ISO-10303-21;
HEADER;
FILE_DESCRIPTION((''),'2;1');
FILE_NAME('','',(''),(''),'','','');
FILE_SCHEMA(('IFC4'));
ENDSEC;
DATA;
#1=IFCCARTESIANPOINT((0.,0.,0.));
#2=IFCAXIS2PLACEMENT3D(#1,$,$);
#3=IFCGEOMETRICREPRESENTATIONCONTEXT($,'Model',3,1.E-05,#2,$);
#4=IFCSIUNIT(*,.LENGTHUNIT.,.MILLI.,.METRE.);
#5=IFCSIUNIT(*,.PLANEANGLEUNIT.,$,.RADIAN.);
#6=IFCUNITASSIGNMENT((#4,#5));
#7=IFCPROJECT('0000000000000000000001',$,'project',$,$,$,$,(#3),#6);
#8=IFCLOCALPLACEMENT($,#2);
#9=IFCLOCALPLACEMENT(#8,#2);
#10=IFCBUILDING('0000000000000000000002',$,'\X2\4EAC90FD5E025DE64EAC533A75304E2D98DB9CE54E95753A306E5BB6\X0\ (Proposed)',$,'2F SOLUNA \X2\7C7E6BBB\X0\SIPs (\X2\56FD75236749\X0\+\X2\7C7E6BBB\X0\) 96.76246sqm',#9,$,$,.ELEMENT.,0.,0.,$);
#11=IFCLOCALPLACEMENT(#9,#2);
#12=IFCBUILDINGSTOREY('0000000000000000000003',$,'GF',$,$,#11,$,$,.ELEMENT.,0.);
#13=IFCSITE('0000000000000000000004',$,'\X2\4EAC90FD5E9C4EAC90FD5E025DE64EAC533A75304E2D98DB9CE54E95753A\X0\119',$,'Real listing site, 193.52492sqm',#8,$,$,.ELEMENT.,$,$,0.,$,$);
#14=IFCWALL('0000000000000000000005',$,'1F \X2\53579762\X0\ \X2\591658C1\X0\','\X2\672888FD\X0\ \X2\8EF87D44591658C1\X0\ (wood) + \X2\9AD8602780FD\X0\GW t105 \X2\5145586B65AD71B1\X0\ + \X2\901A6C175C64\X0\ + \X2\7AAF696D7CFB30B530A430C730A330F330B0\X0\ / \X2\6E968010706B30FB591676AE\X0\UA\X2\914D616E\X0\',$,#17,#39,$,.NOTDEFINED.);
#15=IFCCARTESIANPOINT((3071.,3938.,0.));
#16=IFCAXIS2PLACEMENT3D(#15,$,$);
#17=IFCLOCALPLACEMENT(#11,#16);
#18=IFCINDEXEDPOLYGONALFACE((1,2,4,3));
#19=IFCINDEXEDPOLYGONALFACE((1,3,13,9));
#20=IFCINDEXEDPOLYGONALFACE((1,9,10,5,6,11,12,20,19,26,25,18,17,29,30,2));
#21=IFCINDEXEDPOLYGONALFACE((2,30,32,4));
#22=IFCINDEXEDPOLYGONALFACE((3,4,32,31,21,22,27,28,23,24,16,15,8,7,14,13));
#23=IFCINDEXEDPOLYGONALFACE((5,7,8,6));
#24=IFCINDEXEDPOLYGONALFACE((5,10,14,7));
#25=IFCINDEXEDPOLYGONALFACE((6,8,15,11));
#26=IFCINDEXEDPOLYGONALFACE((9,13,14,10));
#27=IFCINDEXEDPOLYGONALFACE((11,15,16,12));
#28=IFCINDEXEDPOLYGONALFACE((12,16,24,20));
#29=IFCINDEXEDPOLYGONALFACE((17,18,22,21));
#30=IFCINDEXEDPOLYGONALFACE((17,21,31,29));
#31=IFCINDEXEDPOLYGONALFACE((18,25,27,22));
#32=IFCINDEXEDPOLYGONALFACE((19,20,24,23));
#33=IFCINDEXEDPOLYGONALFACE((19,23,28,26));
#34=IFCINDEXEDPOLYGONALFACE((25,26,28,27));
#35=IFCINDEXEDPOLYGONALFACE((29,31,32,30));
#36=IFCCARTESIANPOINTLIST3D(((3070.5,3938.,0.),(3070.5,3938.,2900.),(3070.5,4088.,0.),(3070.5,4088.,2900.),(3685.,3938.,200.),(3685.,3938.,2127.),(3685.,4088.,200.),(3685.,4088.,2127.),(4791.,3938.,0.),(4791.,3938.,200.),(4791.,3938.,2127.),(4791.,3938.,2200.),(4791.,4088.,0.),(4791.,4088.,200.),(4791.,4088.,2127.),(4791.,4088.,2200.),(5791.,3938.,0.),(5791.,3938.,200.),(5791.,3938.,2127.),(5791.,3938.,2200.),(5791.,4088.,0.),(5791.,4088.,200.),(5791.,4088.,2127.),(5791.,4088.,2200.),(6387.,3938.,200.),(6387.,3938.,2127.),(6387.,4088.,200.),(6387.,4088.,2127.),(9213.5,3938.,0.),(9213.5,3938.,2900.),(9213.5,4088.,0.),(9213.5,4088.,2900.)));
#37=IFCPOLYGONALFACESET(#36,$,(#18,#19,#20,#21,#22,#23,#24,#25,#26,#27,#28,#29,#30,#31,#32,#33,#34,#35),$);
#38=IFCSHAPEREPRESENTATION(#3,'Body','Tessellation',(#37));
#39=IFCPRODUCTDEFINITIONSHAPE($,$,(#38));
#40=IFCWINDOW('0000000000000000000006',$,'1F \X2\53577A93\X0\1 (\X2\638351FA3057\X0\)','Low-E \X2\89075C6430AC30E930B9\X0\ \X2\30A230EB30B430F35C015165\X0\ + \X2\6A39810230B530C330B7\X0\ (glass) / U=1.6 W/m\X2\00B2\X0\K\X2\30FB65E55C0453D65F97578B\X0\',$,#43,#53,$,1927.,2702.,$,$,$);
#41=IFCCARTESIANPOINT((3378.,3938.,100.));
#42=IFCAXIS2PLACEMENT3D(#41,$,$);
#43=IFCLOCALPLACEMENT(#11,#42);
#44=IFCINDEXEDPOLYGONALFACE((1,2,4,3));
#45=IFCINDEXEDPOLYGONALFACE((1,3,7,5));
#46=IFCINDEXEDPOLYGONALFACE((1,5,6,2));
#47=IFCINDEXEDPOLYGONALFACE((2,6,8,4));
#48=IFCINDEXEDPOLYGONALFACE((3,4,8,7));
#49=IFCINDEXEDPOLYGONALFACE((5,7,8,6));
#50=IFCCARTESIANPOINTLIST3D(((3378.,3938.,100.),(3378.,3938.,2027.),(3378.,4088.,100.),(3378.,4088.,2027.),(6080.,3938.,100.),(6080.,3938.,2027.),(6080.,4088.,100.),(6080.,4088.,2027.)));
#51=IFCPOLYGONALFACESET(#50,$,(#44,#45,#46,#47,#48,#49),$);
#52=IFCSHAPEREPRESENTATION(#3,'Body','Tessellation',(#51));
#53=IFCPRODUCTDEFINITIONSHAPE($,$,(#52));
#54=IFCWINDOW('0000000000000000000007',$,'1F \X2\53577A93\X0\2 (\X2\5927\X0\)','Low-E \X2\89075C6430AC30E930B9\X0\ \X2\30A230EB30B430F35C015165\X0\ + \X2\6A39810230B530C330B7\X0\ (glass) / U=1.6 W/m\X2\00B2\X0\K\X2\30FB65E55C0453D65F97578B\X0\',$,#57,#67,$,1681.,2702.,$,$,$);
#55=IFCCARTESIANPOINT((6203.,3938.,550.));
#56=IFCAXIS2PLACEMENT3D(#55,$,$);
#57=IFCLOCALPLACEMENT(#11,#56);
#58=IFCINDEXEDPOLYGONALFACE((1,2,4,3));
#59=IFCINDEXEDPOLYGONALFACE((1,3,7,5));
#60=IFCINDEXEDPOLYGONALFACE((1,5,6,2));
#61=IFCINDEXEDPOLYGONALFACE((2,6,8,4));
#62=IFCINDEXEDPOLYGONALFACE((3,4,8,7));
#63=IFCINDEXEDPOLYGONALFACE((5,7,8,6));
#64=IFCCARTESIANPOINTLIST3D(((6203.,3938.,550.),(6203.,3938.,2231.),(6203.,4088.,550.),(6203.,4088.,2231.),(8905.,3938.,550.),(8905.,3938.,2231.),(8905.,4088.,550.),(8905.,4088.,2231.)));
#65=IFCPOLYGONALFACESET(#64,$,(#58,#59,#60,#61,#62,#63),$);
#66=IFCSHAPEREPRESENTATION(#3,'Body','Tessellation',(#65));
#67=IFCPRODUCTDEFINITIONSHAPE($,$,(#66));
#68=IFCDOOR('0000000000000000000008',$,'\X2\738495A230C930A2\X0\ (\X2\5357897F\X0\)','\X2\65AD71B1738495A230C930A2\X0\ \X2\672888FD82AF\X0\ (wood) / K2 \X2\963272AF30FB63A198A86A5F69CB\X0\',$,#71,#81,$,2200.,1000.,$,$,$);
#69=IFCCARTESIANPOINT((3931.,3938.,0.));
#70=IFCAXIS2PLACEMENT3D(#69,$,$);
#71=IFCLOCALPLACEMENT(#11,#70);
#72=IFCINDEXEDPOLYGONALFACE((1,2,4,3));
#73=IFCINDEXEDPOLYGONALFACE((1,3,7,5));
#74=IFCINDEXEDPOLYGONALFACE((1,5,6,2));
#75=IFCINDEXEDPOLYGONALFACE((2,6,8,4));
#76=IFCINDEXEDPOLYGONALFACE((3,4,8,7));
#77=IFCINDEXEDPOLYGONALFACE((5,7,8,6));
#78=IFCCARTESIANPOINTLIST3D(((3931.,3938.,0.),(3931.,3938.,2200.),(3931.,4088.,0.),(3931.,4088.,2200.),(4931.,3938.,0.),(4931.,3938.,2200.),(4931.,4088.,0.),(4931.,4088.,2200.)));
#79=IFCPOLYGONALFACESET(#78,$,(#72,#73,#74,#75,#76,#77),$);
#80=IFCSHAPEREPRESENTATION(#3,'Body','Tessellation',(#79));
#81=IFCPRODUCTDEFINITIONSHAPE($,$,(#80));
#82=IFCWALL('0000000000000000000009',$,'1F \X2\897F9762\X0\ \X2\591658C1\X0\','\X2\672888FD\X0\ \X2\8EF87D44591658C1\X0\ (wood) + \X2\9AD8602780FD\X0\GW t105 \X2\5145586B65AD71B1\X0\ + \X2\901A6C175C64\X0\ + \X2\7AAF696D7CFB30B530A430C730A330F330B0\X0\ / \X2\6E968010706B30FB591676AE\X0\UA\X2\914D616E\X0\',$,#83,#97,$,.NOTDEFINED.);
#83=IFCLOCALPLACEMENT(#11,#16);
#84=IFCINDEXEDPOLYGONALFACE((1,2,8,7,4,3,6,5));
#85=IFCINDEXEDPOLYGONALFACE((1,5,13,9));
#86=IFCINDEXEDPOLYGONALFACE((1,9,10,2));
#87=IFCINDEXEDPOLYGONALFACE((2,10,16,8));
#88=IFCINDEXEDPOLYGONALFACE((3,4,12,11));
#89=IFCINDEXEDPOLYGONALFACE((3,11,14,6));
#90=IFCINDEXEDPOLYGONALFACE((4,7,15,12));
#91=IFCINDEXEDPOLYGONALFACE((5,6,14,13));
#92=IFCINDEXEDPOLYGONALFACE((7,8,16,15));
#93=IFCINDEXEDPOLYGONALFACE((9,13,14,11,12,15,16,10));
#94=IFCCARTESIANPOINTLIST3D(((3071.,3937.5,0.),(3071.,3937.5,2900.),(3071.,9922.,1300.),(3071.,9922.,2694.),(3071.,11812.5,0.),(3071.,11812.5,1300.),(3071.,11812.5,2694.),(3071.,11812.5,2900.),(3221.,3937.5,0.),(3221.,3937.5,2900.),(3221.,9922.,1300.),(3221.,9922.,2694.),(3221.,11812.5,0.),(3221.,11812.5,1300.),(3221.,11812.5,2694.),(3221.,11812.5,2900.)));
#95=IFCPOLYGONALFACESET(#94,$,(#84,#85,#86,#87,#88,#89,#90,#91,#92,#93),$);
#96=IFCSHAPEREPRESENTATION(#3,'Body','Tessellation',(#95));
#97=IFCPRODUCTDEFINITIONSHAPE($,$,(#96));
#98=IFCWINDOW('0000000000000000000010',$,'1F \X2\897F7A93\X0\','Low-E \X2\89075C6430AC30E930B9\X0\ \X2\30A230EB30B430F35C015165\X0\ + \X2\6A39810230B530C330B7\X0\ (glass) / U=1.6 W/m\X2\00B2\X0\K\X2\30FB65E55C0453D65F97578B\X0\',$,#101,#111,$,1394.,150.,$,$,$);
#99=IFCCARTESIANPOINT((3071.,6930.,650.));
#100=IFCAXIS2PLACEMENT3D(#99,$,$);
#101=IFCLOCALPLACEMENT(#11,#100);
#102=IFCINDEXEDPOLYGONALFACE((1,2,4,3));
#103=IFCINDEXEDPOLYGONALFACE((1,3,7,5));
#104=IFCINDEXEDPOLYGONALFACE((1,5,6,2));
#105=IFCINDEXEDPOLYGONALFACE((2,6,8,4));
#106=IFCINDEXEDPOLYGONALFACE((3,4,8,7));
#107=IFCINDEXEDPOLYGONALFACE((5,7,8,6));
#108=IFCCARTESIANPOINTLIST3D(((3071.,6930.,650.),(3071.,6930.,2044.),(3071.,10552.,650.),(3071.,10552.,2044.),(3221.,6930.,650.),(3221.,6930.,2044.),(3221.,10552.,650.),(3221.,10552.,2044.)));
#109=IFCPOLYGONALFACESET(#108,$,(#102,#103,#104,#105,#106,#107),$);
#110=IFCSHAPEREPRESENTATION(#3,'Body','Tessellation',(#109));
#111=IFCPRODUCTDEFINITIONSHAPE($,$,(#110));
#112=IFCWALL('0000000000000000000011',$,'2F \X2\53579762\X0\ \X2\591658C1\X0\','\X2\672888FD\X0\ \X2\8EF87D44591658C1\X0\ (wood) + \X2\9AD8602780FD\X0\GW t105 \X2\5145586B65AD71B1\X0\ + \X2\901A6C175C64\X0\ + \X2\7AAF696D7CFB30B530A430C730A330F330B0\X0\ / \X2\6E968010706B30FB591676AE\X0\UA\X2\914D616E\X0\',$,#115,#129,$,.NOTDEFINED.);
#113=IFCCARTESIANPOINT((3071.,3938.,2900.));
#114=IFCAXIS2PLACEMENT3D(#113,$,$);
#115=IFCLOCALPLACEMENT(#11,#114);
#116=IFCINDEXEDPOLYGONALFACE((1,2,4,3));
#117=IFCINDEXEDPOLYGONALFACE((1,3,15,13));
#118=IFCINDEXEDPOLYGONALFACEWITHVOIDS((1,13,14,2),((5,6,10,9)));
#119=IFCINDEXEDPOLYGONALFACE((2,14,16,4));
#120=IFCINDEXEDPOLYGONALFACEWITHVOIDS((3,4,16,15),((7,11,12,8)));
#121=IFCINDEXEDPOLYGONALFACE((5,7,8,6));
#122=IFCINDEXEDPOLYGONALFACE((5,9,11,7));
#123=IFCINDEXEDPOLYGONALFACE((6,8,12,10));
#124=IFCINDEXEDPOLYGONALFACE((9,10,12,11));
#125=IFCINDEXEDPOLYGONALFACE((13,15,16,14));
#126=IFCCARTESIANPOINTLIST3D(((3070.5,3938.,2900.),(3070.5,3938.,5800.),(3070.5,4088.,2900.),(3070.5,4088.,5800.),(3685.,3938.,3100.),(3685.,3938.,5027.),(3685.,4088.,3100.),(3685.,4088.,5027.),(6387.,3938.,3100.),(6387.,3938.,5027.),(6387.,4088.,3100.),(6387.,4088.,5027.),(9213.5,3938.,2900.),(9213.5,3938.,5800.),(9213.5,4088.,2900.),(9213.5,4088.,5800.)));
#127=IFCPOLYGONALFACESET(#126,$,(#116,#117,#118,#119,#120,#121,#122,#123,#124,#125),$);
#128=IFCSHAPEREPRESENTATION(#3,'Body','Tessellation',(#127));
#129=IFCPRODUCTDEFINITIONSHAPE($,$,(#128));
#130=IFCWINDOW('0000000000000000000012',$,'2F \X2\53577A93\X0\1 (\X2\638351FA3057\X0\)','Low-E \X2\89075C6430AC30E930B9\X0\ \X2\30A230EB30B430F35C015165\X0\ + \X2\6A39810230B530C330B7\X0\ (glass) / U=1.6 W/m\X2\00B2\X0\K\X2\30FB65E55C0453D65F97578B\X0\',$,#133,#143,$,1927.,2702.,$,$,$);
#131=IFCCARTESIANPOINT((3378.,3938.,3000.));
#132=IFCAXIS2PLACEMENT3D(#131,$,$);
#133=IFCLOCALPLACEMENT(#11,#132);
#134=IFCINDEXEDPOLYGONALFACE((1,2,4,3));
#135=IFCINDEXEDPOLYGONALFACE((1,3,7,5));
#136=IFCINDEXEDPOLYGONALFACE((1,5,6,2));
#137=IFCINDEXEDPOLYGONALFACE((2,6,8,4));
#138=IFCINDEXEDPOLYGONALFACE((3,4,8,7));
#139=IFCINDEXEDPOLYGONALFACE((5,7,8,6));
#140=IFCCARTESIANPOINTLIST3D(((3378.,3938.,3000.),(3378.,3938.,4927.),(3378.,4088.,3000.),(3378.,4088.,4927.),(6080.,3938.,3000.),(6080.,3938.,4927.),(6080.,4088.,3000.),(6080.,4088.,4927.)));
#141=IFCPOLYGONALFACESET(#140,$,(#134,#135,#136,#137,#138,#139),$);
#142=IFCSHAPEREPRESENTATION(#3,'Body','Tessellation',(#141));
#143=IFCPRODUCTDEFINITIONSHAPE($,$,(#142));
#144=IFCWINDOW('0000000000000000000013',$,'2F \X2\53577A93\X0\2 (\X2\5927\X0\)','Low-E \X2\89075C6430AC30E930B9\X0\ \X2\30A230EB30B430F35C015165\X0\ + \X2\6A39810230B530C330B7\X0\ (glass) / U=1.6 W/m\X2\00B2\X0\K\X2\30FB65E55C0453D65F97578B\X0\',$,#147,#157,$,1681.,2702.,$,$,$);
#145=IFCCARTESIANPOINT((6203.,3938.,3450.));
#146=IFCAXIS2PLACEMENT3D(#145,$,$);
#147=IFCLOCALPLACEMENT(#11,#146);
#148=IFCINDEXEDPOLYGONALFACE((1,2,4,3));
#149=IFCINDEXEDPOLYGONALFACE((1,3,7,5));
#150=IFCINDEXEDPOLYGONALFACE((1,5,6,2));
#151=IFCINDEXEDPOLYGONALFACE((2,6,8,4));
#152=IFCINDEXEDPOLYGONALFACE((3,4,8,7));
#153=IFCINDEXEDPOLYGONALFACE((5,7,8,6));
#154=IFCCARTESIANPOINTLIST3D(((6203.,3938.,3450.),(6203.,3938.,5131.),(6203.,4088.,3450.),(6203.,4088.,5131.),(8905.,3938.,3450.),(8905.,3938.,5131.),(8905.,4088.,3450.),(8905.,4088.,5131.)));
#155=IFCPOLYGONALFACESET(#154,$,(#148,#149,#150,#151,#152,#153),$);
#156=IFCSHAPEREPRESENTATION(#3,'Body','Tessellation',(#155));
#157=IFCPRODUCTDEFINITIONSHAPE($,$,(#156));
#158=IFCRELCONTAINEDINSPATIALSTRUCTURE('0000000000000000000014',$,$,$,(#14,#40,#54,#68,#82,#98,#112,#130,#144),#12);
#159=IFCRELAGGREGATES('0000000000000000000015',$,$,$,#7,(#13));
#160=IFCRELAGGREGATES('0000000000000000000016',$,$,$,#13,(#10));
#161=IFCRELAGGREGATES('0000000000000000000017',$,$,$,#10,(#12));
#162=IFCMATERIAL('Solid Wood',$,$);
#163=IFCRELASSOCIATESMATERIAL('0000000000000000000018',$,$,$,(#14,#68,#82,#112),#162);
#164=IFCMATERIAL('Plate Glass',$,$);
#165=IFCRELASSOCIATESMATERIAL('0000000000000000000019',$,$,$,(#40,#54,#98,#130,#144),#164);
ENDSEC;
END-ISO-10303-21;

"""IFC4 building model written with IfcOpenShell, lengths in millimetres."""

from ifc_helpers import new_model, si_unit, frame, frame_2d, origin, place, context, project, spatial, rectangle, extrude, material, element, fill, save


model = new_model("IFC4")

# Units and contexts
model_context = context("Model", 3, precision=1e-05, world=origin())
ifc_project = project(units=[si_unit("LENGTHUNIT", "METRE", prefix="MILLI"), si_unit("PLANEANGLEUNIT", "RADIAN")], contexts=[model_context])

# Site, building, storey
site_placement = place(None, origin())
site = spatial("IfcSite", under=ifc_project, at=site_placement, Name="京都府京都市左京区田中飛鳥井町119", ObjectType="Real listing site, 193.52492sqm", CompositionType="ELEMENT", RefElevation=0.0)
building_placement = place(site_placement, origin())
building = spatial("IfcBuilding", under=site, at=building_placement, Name="京都市左京区田中飛鳥井町の家 (Proposed)", ObjectType="2F SOLUNA 籾殻SIPs (国産杉+籾殻) 96.76246sqm", CompositionType="ELEMENT", ElevationOfRefHeight=0.0, ElevationOfTerrain=0.0)
storey_placement = place(building_placement, origin())
storey = spatial("IfcBuildingStorey", under=building, at=storey_placement, Name="GF", CompositionType="ELEMENT", Elevation=0.0)

# Shared definitions
ifc_material_1 = material(Name="Solid Wood")

# Wall, openings, windows, door
wall_1_placement = place(storey_placement, frame((3071.0, 3938.0, 0.0)))
wall_1 = element("IfcWall", 1, at=wall_1_placement, inside=storey, material=ifc_material_1, Name="1F 南面 外壁", Description="木製 軸組外壁 (wood) + 高性能GW t105 充填断熱 + 通気層 + 窯業系サイディング / 準耐火・外皮UA配慮", PredefinedType="NOTDEFINED", context=model_context, shape_type="SweptSolid", body=[
    extrude(rectangle(XDim=6143.0, YDim=150.0, at=frame_2d((3071.0, 75.0))), frame((3071.0, 3938.0, 0.0)), (0.0, 0.0, 1.0), 2900.0),
])
opening_1_placement = place(storey_placement, frame((3378.0, 3938.0, 100.0)))
opening_1 = element("IfcOpeningElement", 2, at=opening_1_placement, cuts=wall_1, PredefinedType="NOTDEFINED", context=model_context, shape_type="SweptSolid", body=[
    extrude(rectangle(XDim=2702.0, YDim=150.0, at=frame_2d((1351.0, 75.0))), frame((3378.0, 3938.0, 100.0)), (0.0, 0.0, 1.0), 1927.0),
])
opening_2_placement = place(storey_placement, frame((6203.0, 3938.0, 550.0)))
opening_2 = element("IfcOpeningElement", 3, at=opening_2_placement, cuts=wall_1, PredefinedType="NOTDEFINED", context=model_context, shape_type="SweptSolid", body=[
    extrude(rectangle(XDim=2702.0, YDim=150.0, at=frame_2d((1351.0, 75.0))), frame((6203.0, 3938.0, 550.0)), (0.0, 0.0, 1.0), 1681.0),
])
opening_3_placement = place(storey_placement, frame((3931.0, 3938.0, 0.0)))
opening_3 = element("IfcOpeningElement", 4, at=opening_3_placement, cuts=wall_1, PredefinedType="NOTDEFINED", context=model_context, shape_type="SweptSolid", body=[
    extrude(rectangle(XDim=1000.0, YDim=150.0, at=frame_2d((500.0, 75.0))), frame((3931.0, 3938.0, 0.0)), (0.0, 0.0, 1.0), 2200.0),
])
ifc_material_2 = material(Name="Plate Glass")
window_1_placement = place(storey_placement, frame((3378.0, 3938.0, 100.0)))
window_1 = element("IfcWindow", 5, at=window_1_placement, inside=storey, material=ifc_material_2, Name="1F 南窓1 (掃出し)", Description="Low-E 複層ガラス アルゴン封入 + 樹脂サッシ (glass) / U=1.6 W/m²K・日射取得型", OverallHeight=1927.0, OverallWidth=2702.0, context=model_context, shape_type="SweptSolid", body=[
    extrude(rectangle(XDim=2702.0, YDim=150.0, at=frame_2d((1351.0, 75.0))), frame((3378.0, 3938.0, 100.0)), (0.0, 0.0, 1.0), 1927.0),
])
fill(opening_1, window_1)
window_2_placement = place(storey_placement, frame((6203.0, 3938.0, 550.0)))
window_2 = element("IfcWindow", 6, at=window_2_placement, inside=storey, material=ifc_material_2, Name="1F 南窓2 (大)", Description="Low-E 複層ガラス アルゴン封入 + 樹脂サッシ (glass) / U=1.6 W/m²K・日射取得型", OverallHeight=1681.0, OverallWidth=2702.0, context=model_context, shape_type="SweptSolid", body=[
    extrude(rectangle(XDim=2702.0, YDim=150.0, at=frame_2d((1351.0, 75.0))), frame((6203.0, 3938.0, 550.0)), (0.0, 0.0, 1.0), 1681.0),
])
fill(opening_2, window_2)
door_placement = place(storey_placement, frame((3931.0, 3938.0, 0.0)))
door = element("IfcDoor", 7, at=door_placement, inside=storey, material=ifc_material_1, Name="玄関ドア (南西)", Description="断熱玄関ドア 木製芯 (wood) / K2 防犯・採風機構", OverallHeight=2200.0, OverallWidth=1000.0, context=model_context, shape_type="SweptSolid", body=[
    extrude(rectangle(XDim=1000.0, YDim=150.0, at=frame_2d((500.0, 75.0))), frame((3931.0, 3938.0, 0.0)), (0.0, 0.0, 1.0), 2200.0),
])
fill(opening_3, door)

# Wall, opening, window
wall_2_placement = place(storey_placement, frame((3071.0, 3938.0, 0.0)))
wall_2 = element("IfcWall", 8, at=wall_2_placement, inside=storey, material=ifc_material_1, Name="1F 西面 外壁", Description="木製 軸組外壁 (wood) + 高性能GW t105 充填断熱 + 通気層 + 窯業系サイディング / 準耐火・外皮UA配慮", PredefinedType="NOTDEFINED", context=model_context, shape_type="SweptSolid", body=[
    extrude(rectangle(XDim=150.0, YDim=7875.0, at=frame_2d((75.0, 3937.0))), frame((3071.0, 3938.0, 0.0)), (0.0, 0.0, 1.0), 2900.0),
])
opening_4_placement = place(storey_placement, frame((3071.0, 6930.0, 650.0)))
opening_4 = element("IfcOpeningElement", 9, at=opening_4_placement, cuts=wall_2, PredefinedType="NOTDEFINED", context=model_context, shape_type="SweptSolid", body=[
    extrude(rectangle(XDim=150.0, YDim=3622.0, at=frame_2d((75.0, 1811.0))), frame((3071.0, 6930.0, 650.0)), (0.0, 0.0, 1.0), 1394.0),
])
window_3_placement = place(storey_placement, frame((3071.0, 6930.0, 650.0)))
window_3 = element("IfcWindow", 10, at=window_3_placement, inside=storey, material=ifc_material_2, Name="1F 西窓", Description="Low-E 複層ガラス アルゴン封入 + 樹脂サッシ (glass) / U=1.6 W/m²K・日射取得型", OverallHeight=1394.0, OverallWidth=150.0, context=model_context, shape_type="SweptSolid", body=[
    extrude(rectangle(XDim=150.0, YDim=3622.0, at=frame_2d((75.0, 1811.0))), frame((3071.0, 6930.0, 650.0)), (0.0, 0.0, 1.0), 1394.0),
])
fill(opening_4, window_3)

# Wall, openings, windows
wall_3_placement = place(storey_placement, frame((3071.0, 3938.0, 2900.0)))
wall_3 = element("IfcWall", 11, at=wall_3_placement, inside=storey, material=ifc_material_1, Name="2F 南面 外壁", Description="木製 軸組外壁 (wood) + 高性能GW t105 充填断熱 + 通気層 + 窯業系サイディング / 準耐火・外皮UA配慮", PredefinedType="NOTDEFINED", context=model_context, shape_type="SweptSolid", body=[
    extrude(rectangle(XDim=6143.0, YDim=150.0, at=frame_2d((3071.0, 75.0))), frame((3071.0, 3938.0, 2900.0)), (0.0, 0.0, 1.0), 2900.0),
])
opening_5_placement = place(storey_placement, frame((3378.0, 3938.0, 3000.0)))
opening_5 = element("IfcOpeningElement", 12, at=opening_5_placement, cuts=wall_3, PredefinedType="NOTDEFINED", context=model_context, shape_type="SweptSolid", body=[
    extrude(rectangle(XDim=2702.0, YDim=150.0, at=frame_2d((1351.0, 75.0))), frame((3378.0, 3938.0, 3000.0)), (0.0, 0.0, 1.0), 1927.0),
])
opening_6_placement = place(storey_placement, frame((6203.0, 3938.0, 3450.0)))
opening_6 = element("IfcOpeningElement", 13, at=opening_6_placement, cuts=wall_3, PredefinedType="NOTDEFINED", context=model_context, shape_type="SweptSolid", body=[
    extrude(rectangle(XDim=2702.0, YDim=150.0, at=frame_2d((1351.0, 75.0))), frame((6203.0, 3938.0, 3450.0)), (0.0, 0.0, 1.0), 1681.0),
])
window_4_placement = place(storey_placement, frame((3378.0, 3938.0, 3000.0)))
window_4 = element("IfcWindow", 14, at=window_4_placement, inside=storey, material=ifc_material_2, Name="2F 南窓1 (掃出し)", Description="Low-E 複層ガラス アルゴン封入 + 樹脂サッシ (glass) / U=1.6 W/m²K・日射取得型", OverallHeight=1927.0, OverallWidth=2702.0, context=model_context, shape_type="SweptSolid", body=[
    extrude(rectangle(XDim=2702.0, YDim=150.0, at=frame_2d((1351.0, 75.0))), frame((3378.0, 3938.0, 3000.0)), (0.0, 0.0, 1.0), 1927.0),
])
fill(opening_5, window_4)
window_5_placement = place(storey_placement, frame((6203.0, 3938.0, 3450.0)))
window_5 = element("IfcWindow", 15, at=window_5_placement, inside=storey, material=ifc_material_2, Name="2F 南窓2 (大)", Description="Low-E 複層ガラス アルゴン封入 + 樹脂サッシ (glass) / U=1.6 W/m²K・日射取得型", OverallHeight=1681.0, OverallWidth=2702.0, context=model_context, shape_type="SweptSolid", body=[
    extrude(rectangle(XDim=2702.0, YDim=150.0, at=frame_2d((1351.0, 75.0))), frame((6203.0, 3938.0, 3450.0)), (0.0, 0.0, 1.0), 1681.0),
])
fill(opening_6, window_5)

save(model, "model.ifc")
